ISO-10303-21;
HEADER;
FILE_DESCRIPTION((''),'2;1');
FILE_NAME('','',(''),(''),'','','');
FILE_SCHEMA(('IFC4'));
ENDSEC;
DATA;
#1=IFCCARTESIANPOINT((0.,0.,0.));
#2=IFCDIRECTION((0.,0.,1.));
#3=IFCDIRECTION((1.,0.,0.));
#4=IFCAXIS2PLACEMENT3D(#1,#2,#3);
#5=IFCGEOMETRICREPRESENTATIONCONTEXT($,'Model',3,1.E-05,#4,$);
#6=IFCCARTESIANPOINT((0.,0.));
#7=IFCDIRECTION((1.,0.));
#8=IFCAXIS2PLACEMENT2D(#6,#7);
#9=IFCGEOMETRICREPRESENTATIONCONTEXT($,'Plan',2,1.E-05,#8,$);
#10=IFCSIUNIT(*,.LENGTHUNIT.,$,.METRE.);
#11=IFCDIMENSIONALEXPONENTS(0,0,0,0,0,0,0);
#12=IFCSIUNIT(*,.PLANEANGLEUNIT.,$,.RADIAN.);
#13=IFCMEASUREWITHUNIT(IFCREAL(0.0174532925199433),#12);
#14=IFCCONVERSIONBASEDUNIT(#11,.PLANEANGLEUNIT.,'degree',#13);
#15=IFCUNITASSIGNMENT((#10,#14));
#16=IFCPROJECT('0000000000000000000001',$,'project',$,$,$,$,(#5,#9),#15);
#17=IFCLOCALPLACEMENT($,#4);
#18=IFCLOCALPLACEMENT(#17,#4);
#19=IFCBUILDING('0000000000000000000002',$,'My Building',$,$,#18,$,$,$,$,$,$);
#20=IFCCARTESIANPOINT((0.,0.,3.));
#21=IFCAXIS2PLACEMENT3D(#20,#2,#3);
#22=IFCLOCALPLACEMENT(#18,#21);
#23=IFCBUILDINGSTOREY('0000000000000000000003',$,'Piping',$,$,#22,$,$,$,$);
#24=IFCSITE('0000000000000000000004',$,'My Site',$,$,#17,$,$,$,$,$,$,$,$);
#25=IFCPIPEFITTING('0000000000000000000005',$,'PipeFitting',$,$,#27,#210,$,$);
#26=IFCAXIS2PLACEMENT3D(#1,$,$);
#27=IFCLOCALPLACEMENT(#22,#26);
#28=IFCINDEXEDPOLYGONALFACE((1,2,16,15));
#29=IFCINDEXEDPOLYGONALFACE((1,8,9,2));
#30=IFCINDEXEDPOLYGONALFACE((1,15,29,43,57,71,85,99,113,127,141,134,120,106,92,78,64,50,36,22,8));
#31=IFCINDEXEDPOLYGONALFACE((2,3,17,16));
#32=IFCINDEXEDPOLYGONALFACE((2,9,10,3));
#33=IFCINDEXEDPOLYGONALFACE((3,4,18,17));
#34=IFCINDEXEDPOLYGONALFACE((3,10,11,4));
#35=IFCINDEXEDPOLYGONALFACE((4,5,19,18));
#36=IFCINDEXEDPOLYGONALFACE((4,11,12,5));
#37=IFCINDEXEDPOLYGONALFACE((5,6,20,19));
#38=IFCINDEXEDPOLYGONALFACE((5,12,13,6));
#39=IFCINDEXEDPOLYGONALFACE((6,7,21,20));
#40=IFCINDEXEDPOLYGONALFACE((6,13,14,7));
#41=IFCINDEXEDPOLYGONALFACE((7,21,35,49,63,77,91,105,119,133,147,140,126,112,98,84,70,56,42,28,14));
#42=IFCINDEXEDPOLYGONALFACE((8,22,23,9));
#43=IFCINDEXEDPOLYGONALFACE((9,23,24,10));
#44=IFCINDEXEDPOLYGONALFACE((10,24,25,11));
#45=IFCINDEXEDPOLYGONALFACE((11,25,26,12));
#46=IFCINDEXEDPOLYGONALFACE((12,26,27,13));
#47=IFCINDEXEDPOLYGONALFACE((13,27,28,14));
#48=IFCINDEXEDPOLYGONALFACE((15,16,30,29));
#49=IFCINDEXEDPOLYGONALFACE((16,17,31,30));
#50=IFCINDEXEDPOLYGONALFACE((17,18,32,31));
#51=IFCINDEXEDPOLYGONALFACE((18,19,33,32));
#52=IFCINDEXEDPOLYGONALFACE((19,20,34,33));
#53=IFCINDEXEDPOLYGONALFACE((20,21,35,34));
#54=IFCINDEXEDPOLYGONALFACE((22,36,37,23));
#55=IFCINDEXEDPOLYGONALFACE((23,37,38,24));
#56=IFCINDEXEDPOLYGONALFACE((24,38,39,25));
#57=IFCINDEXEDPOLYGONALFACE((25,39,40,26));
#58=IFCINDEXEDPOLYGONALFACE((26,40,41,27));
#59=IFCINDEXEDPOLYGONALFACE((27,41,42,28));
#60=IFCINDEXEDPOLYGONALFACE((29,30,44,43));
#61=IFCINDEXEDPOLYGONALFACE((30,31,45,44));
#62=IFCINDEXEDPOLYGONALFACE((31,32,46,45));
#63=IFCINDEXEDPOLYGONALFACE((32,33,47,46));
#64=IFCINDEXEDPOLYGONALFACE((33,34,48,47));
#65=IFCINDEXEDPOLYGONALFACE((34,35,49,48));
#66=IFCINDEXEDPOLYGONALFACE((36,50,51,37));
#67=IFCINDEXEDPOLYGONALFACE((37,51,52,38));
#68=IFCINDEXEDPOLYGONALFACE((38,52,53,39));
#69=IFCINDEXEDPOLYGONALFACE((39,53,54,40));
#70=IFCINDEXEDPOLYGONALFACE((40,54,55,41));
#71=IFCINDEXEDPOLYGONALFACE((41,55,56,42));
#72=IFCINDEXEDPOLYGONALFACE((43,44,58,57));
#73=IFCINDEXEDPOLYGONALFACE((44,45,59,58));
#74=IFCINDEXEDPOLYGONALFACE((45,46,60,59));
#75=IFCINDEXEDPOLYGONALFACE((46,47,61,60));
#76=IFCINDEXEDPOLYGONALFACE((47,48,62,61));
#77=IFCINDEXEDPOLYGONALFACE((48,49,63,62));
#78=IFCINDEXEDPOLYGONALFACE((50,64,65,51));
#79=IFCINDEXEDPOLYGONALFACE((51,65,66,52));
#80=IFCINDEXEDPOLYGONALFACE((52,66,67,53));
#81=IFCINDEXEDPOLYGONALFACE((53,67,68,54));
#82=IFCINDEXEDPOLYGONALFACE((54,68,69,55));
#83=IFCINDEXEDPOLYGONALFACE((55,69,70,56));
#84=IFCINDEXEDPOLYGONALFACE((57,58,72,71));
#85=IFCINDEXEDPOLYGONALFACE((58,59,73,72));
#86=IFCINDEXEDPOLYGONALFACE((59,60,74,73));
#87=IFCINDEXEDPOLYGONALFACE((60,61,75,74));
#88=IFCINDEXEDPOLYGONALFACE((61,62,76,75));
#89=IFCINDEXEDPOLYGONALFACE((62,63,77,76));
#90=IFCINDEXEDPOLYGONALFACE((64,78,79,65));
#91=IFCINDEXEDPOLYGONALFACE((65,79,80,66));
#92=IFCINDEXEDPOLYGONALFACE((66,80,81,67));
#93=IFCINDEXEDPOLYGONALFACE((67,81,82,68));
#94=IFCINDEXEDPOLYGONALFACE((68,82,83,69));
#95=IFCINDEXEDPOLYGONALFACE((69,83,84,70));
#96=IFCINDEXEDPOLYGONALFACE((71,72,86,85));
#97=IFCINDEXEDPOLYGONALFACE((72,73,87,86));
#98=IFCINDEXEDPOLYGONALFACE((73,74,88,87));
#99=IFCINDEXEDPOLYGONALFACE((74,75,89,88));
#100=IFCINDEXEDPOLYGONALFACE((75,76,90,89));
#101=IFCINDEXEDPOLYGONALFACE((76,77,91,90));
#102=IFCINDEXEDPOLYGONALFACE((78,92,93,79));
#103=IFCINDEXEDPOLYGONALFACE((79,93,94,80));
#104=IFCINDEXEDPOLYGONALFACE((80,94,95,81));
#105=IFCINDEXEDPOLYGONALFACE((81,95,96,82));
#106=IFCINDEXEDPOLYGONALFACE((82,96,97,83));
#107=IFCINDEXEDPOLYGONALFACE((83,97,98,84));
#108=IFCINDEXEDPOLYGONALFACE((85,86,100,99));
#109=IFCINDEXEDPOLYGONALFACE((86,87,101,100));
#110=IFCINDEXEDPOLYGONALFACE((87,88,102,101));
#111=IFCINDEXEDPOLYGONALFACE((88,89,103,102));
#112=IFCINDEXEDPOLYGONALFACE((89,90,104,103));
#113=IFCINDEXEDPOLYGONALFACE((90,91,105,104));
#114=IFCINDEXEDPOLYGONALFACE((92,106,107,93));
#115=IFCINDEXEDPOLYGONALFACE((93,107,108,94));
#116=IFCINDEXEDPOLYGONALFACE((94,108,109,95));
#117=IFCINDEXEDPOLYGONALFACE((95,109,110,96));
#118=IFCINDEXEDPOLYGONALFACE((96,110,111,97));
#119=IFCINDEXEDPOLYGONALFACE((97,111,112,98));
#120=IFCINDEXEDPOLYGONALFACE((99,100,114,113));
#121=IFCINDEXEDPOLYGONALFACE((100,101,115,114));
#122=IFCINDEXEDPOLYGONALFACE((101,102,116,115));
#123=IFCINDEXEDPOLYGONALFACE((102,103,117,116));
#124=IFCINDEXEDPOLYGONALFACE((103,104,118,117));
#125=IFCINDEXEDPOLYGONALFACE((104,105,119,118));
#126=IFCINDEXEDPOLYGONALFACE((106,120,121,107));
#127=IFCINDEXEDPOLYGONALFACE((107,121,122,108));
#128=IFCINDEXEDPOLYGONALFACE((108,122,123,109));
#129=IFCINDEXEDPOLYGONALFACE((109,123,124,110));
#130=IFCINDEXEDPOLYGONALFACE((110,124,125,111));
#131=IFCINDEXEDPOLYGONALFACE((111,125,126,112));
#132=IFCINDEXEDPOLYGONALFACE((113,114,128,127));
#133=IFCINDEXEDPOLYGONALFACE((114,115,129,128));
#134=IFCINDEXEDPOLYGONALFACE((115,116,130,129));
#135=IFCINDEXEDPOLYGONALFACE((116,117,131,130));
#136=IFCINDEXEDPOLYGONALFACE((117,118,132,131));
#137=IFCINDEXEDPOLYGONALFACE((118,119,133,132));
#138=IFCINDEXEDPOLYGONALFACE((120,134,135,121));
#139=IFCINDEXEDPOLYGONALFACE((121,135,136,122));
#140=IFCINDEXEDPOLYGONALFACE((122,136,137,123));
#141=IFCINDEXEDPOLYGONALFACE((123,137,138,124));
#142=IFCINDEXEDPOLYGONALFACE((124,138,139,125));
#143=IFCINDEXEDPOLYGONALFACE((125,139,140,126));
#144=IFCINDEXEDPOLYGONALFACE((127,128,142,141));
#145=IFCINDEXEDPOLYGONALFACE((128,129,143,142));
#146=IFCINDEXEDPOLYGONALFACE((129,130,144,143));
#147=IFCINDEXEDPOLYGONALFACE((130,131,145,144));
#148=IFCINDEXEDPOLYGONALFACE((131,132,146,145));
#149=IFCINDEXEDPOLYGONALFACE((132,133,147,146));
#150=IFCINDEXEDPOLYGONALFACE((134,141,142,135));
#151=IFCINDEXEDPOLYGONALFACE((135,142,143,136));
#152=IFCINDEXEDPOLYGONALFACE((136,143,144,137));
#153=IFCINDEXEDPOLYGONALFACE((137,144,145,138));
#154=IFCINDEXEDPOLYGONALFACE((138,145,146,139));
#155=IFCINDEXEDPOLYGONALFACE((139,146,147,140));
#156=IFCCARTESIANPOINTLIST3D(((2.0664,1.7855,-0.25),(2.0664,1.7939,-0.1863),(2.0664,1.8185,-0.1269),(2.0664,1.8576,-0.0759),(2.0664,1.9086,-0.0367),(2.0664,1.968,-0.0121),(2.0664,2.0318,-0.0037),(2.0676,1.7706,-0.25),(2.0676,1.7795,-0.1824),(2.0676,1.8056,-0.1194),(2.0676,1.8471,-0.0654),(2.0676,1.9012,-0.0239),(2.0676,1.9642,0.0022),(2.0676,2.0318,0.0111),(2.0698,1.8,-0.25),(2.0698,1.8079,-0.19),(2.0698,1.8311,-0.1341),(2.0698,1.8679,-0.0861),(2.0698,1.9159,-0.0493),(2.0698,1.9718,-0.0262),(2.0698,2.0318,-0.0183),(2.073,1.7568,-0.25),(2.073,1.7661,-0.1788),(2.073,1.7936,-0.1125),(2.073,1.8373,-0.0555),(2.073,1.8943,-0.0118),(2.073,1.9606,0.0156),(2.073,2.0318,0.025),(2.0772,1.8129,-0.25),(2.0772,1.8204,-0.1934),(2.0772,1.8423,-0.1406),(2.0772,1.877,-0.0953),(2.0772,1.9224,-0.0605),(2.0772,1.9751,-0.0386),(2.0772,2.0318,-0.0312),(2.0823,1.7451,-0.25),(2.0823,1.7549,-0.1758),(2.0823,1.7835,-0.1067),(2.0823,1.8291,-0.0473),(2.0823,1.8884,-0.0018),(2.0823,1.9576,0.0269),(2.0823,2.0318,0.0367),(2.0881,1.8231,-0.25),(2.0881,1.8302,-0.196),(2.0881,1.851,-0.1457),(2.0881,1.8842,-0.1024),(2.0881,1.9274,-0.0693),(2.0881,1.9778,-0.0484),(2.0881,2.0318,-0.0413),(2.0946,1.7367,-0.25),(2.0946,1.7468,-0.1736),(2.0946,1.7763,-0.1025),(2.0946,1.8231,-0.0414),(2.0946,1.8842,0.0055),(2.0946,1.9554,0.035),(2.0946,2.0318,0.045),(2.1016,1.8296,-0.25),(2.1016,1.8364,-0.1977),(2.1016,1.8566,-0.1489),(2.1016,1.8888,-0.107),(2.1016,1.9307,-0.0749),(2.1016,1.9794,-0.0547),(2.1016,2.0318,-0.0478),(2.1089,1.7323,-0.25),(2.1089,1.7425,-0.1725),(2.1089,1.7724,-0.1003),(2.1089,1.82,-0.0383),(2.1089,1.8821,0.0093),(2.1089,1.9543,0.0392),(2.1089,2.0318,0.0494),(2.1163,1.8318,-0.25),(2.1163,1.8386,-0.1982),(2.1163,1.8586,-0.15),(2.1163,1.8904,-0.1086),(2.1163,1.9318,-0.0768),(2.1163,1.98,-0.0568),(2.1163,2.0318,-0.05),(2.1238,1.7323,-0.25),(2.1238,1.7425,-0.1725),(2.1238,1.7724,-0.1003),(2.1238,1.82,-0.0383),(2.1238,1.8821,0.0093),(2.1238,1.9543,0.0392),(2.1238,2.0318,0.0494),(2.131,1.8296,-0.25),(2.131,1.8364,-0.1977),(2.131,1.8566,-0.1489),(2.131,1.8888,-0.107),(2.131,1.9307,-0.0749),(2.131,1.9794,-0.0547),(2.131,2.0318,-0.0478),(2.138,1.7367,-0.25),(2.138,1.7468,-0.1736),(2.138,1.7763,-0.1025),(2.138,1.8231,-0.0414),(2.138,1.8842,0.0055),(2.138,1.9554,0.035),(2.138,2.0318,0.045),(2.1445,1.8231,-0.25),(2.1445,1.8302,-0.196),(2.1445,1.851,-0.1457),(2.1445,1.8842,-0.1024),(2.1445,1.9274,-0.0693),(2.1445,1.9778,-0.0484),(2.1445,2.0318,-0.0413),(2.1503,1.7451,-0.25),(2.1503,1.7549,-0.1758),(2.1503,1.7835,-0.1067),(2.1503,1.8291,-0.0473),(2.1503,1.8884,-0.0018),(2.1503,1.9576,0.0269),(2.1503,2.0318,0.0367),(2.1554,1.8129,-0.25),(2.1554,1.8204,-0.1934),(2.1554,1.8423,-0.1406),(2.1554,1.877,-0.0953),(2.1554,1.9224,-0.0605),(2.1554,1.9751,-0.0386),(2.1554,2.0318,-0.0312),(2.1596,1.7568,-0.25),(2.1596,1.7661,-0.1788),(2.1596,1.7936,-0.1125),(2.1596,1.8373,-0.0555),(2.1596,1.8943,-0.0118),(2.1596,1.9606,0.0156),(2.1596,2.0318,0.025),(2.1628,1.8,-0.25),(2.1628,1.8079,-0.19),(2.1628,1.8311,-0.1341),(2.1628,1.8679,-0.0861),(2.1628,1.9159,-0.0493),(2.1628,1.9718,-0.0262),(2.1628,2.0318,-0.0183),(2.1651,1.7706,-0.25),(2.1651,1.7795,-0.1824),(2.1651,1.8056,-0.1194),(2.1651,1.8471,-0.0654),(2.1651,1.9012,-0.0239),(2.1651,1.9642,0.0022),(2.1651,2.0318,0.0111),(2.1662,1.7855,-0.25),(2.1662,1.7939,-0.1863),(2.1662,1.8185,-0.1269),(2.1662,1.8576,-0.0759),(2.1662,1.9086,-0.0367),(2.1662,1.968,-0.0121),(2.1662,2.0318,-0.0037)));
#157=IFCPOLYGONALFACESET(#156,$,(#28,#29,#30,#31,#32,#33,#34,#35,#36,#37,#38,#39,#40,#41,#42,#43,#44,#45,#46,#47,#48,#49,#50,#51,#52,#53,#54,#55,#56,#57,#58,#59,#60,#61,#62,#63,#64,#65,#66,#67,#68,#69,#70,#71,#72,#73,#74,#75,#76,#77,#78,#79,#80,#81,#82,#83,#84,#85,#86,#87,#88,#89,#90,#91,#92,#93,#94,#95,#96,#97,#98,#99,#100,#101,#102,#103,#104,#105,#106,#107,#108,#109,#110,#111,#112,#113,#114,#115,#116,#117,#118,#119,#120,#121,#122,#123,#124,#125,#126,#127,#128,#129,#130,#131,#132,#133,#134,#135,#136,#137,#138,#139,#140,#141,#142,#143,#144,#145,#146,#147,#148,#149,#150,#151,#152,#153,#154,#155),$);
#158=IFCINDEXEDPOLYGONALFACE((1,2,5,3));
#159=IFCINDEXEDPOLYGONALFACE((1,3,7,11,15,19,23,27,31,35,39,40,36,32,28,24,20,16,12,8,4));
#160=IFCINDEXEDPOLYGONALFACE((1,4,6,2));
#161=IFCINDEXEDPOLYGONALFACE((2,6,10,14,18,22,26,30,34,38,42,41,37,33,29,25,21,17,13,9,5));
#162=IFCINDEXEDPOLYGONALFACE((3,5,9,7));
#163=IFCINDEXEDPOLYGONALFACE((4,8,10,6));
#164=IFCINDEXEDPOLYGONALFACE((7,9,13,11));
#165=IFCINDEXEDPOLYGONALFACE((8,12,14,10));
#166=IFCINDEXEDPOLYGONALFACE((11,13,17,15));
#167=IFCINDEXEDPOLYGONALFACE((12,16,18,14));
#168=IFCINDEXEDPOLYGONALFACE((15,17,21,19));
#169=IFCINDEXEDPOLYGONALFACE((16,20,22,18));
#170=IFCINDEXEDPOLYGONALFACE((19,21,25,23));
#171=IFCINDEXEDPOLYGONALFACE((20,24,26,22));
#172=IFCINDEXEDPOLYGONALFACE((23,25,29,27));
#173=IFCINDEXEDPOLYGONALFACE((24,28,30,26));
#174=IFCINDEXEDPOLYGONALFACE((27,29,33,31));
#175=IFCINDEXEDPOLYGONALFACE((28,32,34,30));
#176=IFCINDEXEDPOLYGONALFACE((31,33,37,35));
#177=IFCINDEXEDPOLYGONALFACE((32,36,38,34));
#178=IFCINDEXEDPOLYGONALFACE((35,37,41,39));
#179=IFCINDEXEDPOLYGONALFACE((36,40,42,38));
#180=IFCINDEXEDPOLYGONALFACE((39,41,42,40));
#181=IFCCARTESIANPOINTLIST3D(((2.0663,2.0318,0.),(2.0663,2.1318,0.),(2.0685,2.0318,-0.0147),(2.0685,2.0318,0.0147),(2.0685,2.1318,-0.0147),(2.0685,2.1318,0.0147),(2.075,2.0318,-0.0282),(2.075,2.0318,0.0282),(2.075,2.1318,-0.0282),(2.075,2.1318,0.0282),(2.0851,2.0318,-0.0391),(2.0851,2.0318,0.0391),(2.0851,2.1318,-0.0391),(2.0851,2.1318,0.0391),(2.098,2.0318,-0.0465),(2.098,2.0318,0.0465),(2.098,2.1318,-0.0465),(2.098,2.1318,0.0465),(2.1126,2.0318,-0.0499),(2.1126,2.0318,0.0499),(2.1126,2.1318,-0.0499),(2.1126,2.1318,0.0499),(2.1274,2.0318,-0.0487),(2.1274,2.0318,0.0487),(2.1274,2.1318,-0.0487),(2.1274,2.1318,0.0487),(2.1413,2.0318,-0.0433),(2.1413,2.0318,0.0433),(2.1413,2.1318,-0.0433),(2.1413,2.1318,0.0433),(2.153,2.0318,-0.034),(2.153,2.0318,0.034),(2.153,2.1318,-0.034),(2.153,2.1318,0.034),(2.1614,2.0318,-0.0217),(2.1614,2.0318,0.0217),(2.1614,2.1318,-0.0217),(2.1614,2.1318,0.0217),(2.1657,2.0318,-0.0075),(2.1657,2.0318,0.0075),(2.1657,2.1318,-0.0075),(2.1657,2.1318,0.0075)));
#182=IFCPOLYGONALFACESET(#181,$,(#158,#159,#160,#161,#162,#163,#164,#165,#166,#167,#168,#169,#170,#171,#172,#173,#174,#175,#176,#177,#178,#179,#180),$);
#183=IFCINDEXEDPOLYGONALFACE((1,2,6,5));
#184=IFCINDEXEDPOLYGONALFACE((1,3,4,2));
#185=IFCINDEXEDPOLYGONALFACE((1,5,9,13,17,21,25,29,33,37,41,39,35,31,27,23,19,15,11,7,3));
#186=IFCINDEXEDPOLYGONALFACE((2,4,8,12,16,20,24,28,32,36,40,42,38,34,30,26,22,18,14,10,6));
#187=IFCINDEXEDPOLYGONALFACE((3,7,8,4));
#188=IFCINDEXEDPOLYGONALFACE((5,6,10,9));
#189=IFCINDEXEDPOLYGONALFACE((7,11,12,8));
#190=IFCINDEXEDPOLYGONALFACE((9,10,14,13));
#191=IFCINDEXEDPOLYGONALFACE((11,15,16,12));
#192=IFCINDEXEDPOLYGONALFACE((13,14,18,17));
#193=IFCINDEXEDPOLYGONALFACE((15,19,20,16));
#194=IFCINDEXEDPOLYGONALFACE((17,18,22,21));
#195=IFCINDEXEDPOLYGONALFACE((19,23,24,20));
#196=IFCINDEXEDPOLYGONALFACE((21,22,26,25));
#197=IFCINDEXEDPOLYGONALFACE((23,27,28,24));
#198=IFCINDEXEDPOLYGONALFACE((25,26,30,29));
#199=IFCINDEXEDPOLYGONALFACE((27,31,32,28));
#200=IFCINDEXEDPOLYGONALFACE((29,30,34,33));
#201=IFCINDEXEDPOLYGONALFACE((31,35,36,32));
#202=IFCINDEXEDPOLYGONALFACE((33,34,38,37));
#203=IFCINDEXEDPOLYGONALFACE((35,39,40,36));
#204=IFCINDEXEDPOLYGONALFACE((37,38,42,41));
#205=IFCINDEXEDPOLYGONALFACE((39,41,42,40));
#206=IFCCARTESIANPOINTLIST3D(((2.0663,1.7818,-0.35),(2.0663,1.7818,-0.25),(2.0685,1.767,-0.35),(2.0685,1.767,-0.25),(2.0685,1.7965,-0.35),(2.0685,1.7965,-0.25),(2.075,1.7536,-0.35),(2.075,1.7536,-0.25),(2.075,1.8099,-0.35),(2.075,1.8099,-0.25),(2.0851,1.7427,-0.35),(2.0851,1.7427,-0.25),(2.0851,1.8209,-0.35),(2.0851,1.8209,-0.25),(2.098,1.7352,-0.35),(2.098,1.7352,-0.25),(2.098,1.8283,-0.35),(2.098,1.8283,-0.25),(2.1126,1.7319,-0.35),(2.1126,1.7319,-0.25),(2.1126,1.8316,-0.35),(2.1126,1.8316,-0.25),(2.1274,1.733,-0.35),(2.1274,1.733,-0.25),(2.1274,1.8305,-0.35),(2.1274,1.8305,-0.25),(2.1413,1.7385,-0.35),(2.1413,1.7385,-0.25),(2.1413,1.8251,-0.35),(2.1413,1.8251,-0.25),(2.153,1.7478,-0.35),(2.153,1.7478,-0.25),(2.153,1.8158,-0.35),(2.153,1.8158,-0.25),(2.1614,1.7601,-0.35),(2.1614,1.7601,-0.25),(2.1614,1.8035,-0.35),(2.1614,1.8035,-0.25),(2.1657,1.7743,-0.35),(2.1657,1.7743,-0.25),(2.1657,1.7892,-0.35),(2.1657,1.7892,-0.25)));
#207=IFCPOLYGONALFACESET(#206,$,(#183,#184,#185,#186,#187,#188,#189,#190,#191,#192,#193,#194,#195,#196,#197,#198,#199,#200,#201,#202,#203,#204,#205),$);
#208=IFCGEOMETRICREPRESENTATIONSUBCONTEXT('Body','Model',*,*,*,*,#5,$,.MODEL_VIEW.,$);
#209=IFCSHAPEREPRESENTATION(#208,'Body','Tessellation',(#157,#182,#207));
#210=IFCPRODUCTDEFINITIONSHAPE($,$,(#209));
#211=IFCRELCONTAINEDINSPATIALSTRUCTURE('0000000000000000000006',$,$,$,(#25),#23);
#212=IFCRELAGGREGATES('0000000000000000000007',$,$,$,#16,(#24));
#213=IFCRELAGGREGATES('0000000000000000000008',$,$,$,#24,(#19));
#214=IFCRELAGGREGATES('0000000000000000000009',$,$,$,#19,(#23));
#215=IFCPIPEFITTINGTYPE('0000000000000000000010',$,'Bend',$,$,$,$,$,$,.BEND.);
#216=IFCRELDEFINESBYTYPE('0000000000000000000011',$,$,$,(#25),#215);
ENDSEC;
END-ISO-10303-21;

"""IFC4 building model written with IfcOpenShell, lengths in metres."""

from ifc_helpers import new_model, entity, si_unit, converted_unit, frame, origin_with_axes, origin_2d_with_axis, place, context, subcontext, project, spatial, circle, extrude, source, transform, mapped, type_object, type_shapes, element, save


model = new_model("IFC4")

# Units and contexts
model_context = context("Model", 3, precision=1e-05, world=origin_with_axes())
plan_context = context("Plan", 2, precision=1e-05, world=origin_2d_with_axis())
body_context = subcontext(model_context, "Body", "Model", "MODEL_VIEW")
ifc_project = project(units=[si_unit("LENGTHUNIT", "METRE"), converted_unit("PLANEANGLEUNIT", "degree", entity("IfcReal", 0.0174532925199433), si_unit("PLANEANGLEUNIT", "RADIAN"), dimensions=[0, 0, 0, 0, 0, 0, 0])], contexts=[model_context, plan_context])

# Site, building, storey
site_placement = place(None, origin_with_axes())
site = spatial("IfcSite", under=ifc_project, at=site_placement, Name="My Site")
building_placement = place(site_placement, origin_with_axes())
building = spatial("IfcBuilding", under=site, at=building_placement, Name="My Building")
storey_placement = place(building_placement, frame((0.0, 0.0, 3.0), z_axis=(0.0, 0.0, 1.0), x_axis=(1.0, 0.0, 0.0)))
storey = spatial("IfcBuildingStorey", under=building, at=storey_placement, Name="Piping")

# Pipe fitting
pipe_fitting_type = type_object("IfcPipeFittingType", Name="Bend", PredefinedType="BEND")
shared_shape = source(origin_with_axes(), body_context, "Body", "SolidModel", [
    entity("IfcSweptDiskSolid", entity("IfcIndexedPolyCurve", entity("IfcCartesianPointList3D", [[0.0, 0.0, -0.1], [0.0, -0.0732, -0.2768], [0.0, -0.25, -0.35]]), [entity("IfcArcIndex", [1, 2, 3])]), 0.05),
    extrude(circle(Radius=0.05), origin_with_axes(), (0.0, 0.0, -1.0), 0.1),
    extrude(circle(Radius=0.05), frame((0.0, -0.25, -0.35), z_axis=(0.0, -1.0, 0.0), x_axis=(1.0, 0.0, 0.0)), (0.0, 0.0, 1.0), 0.1),
])
type_shapes(pipe_fitting_type, [shared_shape])
for number, where, z_axis, x_axis, name in (
    (1, (2.1163, 2.1318, 0.0), (0.0, 1.0, 0.0), (-1.0, 0.0, 0.0), "PipeFitting"),
):
    element("IfcPipeFitting", number, at=place(storey_placement, frame(where, z_axis=z_axis, x_axis=x_axis)), inside=storey, type_object=pipe_fitting_type, Name=name, context=body_context, shape_type="MappedRepresentation", body=[
        mapped(shared_shape, transform((0.0, 0.0, 0.0), x_axis=(1.0, 0.0, 0.0), y_axis=(0.0, 1.0, 0.0), z_axis=(0.0, 0.0, 1.0), scale=1.0)),
    ])

save(model, "model.ifc")
